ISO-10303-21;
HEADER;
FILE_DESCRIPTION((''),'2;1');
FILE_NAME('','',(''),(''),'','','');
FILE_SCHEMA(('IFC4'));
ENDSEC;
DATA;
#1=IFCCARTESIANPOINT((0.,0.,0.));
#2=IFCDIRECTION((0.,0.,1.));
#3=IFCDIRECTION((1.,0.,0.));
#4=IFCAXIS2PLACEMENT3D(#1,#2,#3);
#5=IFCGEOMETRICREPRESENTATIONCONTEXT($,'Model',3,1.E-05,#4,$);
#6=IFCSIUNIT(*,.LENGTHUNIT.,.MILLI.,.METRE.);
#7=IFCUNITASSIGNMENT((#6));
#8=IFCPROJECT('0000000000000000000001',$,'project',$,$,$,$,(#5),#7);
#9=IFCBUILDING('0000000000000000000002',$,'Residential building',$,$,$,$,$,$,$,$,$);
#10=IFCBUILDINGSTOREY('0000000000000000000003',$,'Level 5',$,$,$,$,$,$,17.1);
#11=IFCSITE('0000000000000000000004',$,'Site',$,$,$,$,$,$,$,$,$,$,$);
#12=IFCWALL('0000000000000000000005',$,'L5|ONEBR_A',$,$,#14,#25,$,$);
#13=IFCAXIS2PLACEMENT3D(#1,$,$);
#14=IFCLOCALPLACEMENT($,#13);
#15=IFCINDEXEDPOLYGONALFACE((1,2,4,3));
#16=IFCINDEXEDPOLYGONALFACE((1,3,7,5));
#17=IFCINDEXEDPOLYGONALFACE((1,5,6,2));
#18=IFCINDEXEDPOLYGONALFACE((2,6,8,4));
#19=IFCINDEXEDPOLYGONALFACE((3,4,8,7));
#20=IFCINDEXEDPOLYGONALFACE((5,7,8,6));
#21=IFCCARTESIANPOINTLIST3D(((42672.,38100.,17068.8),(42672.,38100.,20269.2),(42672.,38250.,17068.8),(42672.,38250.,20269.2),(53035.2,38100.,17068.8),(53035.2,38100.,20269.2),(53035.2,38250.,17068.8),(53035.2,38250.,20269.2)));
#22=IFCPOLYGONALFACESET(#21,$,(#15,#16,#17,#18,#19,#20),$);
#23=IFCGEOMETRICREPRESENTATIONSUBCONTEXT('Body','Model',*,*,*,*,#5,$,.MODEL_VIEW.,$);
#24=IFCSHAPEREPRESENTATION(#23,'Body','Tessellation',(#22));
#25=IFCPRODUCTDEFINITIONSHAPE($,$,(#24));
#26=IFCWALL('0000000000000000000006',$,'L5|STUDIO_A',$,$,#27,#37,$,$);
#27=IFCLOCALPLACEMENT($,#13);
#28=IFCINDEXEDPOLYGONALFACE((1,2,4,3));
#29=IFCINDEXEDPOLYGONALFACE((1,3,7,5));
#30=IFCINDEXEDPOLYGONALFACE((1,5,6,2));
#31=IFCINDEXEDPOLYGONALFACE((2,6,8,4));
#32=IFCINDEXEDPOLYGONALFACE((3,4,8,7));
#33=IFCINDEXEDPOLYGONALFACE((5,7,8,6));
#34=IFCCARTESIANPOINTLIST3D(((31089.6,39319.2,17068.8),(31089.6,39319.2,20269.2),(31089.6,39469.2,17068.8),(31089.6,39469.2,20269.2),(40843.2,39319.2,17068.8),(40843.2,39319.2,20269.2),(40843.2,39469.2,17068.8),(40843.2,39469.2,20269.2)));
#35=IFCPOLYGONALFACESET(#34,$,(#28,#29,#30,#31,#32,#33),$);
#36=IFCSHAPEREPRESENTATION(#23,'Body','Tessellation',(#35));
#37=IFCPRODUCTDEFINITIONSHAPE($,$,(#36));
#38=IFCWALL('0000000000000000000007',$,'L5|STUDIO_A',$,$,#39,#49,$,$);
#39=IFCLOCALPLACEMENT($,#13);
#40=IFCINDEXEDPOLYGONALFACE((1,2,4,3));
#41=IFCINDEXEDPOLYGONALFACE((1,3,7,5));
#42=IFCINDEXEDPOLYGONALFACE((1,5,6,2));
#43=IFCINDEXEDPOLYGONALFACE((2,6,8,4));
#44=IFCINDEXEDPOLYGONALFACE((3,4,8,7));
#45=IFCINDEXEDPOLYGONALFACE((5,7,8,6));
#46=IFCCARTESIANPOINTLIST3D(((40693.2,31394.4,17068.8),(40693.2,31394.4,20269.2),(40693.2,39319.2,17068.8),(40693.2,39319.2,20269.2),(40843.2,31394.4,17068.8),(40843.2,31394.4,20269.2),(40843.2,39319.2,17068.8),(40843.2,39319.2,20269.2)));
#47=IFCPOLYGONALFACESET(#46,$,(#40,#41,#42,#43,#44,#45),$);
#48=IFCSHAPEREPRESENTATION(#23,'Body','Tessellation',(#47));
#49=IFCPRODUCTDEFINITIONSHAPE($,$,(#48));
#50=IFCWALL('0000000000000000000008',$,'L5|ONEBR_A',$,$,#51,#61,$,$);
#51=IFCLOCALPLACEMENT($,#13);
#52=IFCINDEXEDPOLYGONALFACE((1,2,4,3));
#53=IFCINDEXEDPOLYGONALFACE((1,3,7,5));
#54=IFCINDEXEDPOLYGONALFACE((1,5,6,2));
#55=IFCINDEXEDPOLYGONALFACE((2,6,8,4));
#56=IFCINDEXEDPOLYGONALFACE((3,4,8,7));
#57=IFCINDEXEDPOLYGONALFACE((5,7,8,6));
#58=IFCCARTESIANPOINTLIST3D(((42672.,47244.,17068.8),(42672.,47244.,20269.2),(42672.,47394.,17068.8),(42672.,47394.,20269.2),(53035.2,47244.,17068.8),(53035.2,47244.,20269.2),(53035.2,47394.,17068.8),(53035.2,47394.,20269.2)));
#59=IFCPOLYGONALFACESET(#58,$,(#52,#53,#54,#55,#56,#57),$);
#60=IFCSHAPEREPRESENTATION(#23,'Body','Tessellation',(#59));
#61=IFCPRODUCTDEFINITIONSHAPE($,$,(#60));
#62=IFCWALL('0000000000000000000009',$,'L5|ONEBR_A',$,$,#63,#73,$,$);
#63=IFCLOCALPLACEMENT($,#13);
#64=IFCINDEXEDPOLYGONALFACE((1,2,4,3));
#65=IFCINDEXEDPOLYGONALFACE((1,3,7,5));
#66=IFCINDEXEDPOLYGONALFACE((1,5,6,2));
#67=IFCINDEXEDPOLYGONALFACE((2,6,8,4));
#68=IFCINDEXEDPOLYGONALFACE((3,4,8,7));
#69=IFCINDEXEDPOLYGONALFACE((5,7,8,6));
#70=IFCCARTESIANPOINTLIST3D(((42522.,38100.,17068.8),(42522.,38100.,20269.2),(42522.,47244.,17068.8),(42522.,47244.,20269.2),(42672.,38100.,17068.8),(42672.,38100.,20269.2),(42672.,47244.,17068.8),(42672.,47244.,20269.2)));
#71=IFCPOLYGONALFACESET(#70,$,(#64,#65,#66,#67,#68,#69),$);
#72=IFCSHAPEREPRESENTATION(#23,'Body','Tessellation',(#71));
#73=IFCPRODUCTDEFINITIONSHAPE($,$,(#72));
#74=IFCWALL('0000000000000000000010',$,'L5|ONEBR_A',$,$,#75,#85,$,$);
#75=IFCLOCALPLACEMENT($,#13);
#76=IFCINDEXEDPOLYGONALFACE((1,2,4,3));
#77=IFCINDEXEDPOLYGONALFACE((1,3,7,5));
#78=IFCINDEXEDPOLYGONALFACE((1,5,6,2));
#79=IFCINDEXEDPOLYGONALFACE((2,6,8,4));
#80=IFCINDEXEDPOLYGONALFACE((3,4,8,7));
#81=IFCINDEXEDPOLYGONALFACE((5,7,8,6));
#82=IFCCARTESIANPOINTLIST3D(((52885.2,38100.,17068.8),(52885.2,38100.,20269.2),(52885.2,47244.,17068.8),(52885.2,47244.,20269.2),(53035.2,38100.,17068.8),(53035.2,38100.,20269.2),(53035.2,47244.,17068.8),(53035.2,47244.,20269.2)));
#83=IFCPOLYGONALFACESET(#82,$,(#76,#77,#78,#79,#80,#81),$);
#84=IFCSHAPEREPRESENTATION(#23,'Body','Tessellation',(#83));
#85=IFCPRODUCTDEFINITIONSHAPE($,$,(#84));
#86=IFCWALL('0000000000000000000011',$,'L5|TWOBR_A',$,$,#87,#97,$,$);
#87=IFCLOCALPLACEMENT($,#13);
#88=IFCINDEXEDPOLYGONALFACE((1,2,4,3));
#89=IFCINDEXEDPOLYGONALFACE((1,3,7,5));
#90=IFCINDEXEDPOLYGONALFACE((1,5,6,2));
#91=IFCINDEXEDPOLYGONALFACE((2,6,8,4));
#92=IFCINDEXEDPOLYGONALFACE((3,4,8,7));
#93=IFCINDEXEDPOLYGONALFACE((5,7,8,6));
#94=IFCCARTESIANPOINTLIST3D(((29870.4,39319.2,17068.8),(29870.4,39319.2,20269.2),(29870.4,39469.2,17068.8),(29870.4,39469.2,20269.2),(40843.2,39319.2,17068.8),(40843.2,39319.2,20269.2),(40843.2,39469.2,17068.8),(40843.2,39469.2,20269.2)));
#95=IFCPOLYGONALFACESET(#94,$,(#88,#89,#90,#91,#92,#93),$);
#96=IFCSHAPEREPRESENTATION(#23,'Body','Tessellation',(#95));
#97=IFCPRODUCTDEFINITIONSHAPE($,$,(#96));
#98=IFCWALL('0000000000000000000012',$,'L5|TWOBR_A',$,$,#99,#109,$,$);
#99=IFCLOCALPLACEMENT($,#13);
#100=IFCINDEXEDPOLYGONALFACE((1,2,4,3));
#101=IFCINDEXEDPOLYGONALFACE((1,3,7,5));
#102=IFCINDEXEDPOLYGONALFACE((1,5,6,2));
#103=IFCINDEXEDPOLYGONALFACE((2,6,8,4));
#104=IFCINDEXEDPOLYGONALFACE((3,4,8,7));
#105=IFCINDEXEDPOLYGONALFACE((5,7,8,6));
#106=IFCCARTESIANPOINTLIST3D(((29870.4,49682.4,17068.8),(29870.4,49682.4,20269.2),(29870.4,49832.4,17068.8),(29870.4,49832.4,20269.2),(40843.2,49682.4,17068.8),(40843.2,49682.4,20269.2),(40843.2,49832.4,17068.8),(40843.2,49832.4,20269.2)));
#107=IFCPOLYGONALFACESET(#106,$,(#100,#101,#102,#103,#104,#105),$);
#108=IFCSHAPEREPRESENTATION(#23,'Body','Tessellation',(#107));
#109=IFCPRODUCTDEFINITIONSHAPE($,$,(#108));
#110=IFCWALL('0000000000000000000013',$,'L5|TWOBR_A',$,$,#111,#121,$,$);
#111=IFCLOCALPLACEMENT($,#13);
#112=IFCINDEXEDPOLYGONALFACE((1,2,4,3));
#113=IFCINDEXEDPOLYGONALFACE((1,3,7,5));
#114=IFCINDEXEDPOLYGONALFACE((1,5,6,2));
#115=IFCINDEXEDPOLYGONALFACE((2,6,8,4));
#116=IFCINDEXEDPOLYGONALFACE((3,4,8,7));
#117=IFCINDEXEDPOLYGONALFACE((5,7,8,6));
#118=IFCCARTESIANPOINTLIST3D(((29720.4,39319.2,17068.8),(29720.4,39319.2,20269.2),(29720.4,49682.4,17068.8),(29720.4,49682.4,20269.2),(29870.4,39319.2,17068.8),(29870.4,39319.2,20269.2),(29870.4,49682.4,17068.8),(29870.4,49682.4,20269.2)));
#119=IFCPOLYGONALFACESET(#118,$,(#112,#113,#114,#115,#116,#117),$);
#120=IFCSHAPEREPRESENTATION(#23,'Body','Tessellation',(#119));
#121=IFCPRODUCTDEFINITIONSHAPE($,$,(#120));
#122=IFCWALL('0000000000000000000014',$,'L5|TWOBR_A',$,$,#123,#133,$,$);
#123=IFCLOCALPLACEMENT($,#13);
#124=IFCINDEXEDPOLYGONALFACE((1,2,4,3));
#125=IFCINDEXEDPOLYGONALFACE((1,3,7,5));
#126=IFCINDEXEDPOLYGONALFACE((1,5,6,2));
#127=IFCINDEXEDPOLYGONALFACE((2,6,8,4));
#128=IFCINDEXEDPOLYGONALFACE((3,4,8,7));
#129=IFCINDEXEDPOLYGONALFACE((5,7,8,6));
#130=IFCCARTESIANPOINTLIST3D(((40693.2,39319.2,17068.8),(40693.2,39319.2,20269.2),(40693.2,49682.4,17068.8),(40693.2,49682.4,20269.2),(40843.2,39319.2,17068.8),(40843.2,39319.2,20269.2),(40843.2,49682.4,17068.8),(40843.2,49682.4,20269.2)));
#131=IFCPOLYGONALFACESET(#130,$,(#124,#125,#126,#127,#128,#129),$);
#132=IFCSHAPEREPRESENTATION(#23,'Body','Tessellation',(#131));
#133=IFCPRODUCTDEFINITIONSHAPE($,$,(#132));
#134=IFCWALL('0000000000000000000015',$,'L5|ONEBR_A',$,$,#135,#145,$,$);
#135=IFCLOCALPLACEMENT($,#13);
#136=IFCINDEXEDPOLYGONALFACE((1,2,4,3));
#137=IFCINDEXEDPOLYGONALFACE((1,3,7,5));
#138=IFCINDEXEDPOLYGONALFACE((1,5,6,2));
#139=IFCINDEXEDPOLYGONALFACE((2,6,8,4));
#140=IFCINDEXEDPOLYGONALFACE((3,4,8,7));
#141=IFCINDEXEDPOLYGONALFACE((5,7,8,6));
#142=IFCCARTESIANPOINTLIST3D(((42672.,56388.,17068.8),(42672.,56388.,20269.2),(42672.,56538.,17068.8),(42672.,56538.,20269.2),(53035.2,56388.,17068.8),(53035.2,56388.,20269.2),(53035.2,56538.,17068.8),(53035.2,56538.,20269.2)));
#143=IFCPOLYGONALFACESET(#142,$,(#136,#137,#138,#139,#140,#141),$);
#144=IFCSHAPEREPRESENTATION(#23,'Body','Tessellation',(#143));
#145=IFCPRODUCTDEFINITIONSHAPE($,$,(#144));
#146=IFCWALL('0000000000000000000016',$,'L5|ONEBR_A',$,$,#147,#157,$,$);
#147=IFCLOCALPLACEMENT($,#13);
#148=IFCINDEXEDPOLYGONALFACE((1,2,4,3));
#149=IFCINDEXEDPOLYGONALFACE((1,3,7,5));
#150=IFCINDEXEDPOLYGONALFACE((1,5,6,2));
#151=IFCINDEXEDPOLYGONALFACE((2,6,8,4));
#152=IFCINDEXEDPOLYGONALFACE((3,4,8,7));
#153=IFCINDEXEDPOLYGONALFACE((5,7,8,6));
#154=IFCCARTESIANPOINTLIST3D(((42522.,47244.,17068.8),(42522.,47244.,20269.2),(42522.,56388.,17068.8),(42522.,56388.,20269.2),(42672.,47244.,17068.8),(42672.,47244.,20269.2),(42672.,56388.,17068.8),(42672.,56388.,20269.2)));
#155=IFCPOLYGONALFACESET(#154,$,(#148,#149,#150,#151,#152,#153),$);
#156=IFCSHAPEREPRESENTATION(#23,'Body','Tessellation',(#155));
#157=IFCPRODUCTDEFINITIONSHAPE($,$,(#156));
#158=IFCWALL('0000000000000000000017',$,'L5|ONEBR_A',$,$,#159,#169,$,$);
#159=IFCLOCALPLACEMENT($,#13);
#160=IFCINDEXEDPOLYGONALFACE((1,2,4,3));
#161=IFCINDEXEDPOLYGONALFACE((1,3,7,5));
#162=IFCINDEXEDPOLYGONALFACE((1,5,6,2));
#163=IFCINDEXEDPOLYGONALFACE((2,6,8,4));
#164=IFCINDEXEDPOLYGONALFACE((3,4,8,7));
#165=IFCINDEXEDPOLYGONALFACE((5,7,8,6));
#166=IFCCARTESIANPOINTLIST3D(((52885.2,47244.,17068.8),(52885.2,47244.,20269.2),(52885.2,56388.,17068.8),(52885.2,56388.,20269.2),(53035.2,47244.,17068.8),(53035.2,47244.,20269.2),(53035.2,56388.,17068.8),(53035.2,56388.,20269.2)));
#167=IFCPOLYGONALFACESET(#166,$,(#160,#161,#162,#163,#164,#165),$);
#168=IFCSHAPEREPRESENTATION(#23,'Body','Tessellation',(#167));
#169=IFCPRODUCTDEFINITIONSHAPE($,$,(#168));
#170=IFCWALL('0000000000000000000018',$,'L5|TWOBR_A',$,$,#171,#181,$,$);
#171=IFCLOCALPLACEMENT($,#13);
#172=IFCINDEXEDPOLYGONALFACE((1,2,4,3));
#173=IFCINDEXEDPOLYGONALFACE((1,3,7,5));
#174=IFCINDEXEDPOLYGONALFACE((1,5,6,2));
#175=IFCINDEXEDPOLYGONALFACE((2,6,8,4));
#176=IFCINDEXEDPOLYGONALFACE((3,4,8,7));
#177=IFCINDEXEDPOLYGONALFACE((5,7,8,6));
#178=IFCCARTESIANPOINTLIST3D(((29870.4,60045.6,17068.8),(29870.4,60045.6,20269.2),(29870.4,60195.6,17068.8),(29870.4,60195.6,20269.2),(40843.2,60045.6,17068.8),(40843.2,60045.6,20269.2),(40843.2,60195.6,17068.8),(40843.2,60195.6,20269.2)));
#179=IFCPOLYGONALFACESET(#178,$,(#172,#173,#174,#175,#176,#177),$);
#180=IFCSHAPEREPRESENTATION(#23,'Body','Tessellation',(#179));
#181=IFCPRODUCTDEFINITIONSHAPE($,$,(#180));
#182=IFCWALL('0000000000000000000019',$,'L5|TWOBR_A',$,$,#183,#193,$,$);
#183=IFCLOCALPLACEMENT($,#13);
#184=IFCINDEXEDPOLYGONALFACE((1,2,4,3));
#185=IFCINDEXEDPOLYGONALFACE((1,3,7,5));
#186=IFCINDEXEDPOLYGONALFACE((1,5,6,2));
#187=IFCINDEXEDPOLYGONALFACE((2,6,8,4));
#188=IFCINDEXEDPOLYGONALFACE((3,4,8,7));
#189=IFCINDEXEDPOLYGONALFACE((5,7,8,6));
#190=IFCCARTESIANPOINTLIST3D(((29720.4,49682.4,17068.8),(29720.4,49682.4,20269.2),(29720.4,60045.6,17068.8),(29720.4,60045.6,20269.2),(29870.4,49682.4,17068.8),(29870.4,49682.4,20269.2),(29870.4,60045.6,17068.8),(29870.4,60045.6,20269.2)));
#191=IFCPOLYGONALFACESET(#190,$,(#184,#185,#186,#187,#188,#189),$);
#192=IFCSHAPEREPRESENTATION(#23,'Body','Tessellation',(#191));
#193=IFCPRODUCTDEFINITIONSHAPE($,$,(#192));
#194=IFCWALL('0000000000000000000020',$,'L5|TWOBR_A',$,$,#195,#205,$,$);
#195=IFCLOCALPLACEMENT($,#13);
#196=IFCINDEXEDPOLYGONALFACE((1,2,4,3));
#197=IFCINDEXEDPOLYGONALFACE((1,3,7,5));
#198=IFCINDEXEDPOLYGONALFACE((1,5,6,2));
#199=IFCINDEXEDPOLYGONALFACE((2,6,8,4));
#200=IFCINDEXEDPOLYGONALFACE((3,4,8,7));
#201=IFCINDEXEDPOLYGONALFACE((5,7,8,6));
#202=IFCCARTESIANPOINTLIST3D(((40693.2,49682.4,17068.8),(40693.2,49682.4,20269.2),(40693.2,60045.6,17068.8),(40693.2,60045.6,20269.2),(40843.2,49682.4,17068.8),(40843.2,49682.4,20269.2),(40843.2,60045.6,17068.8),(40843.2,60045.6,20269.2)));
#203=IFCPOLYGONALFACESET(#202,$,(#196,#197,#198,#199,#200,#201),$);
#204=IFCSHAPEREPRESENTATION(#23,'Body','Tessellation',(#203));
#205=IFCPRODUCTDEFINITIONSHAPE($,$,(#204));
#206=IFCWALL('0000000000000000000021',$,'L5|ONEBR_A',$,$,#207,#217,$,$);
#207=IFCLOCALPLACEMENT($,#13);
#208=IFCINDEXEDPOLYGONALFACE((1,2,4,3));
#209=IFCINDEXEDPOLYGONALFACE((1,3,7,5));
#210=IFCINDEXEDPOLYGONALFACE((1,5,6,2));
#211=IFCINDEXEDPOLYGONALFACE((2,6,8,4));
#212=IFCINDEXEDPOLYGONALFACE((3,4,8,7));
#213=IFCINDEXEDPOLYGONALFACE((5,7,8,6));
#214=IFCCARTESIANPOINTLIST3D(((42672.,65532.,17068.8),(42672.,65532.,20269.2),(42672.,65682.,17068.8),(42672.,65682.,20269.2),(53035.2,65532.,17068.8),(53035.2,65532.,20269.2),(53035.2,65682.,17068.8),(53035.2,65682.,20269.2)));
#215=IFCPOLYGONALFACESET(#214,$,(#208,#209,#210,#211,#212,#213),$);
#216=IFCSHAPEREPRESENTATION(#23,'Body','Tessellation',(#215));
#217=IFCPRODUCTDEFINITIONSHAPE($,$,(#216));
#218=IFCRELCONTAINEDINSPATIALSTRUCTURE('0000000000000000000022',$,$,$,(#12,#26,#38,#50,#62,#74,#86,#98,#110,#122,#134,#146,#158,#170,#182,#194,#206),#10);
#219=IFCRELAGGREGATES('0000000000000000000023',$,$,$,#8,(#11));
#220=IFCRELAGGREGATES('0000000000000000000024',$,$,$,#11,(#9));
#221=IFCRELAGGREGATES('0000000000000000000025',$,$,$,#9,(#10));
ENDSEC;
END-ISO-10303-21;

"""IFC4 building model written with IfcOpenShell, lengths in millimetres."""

from ifc_helpers import new_model, si_unit, frame, origin_with_axes, place, context, subcontext, project, spatial, indexed_curve, outline, extrude, element, save


model = new_model("IFC4")

# Units and contexts
model_context = context("Model", 3, precision=1e-05, world=origin_with_axes())
body_context = subcontext(model_context, "Body", "Model", "MODEL_VIEW")
ifc_project = project(units=[si_unit("LENGTHUNIT", "METRE", prefix="MILLI")], contexts=[model_context])

# Site, building, storey
site = spatial("IfcSite", under=ifc_project, Name="Site")
building = spatial("IfcBuilding", under=site, Name="Residential building")
storey = spatial("IfcBuildingStorey", under=building, Name="Level 5", Elevation=17.1)

# Walls
wall_1_placement = place(None, frame((42672.0, 38100.0, 17068.8), z_axis=(0.0, 0.0, 1.0), x_axis=(1.0, 0.0, 0.0)))
element("IfcWall", 1, at=wall_1_placement, inside=storey, Name="L5|ONEBR_A", context=body_context, shape_type="SweptSolid", body=[
    extrude(outline(indexed_curve([(0.0, 0.0), (0.0, 150.0), (10363.2, 150.0), (10363.2, 0.0), (0.0, 0.0)], self_intersect=False)), origin_with_axes(), (0.0, 0.0, 1.0), 3200.4),
])
wall_2_placement = place(None, frame((31089.6, 39319.2, 17068.8), z_axis=(0.0, 0.0, 1.0), x_axis=(1.0, 0.0, 0.0)))
element("IfcWall", 2, at=wall_2_placement, inside=storey, Name="L5|STUDIO_A", context=body_context, shape_type="SweptSolid", body=[
    extrude(outline(indexed_curve([(0.0, 0.0), (0.0, 150.0), (9753.6, 150.0), (9753.6, 0.0), (0.0, 0.0)], self_intersect=False)), origin_with_axes(), (0.0, 0.0, 1.0), 3200.4),
])
wall_3_placement = place(None, frame((40843.2, 31394.4, 17068.8), z_axis=(0.0, 0.0, 1.0), x_axis=(0.0, 1.0, 0.0)))
element("IfcWall", 3, at=wall_3_placement, inside=storey, Name="L5|STUDIO_A", context=body_context, shape_type="SweptSolid", body=[
    extrude(outline(indexed_curve([(0.0, 0.0), (0.0, 150.0), (7924.8, 150.0), (7924.8, 0.0), (0.0, 0.0)], self_intersect=False)), origin_with_axes(), (0.0, 0.0, 1.0), 3200.4),
])
for number, where, z_axis, x_axis, name in (
    (4, (42672.0, 47244.0, 17068.8), (0.0, 0.0, 1.0), (1.0, 0.0, 0.0), "L5|ONEBR_A"),
):
    element("IfcWall", number, at=place(None, frame(where, z_axis=z_axis, x_axis=x_axis)), inside=storey, Name=name, context=body_context, shape_type="SweptSolid", body=[
        extrude(outline(indexed_curve([(0.0, 0.0), (0.0, 150.0), (10363.2, 150.0), (10363.2, 0.0), (0.0, 0.0)], self_intersect=False)), origin_with_axes(), (0.0, 0.0, 1.0), 3200.4),
    ])
for number, where, z_axis, x_axis, name in (
    (5, (42672.0, 38100.0, 17068.8), (0.0, 0.0, 1.0), (0.0, 1.0, 0.0), "L5|ONEBR_A"),
    (6, (53035.2, 38100.0, 17068.8), (0.0, 0.0, 1.0), (0.0, 1.0, 0.0), "L5|ONEBR_A"),
):
    element("IfcWall", number, at=place(None, frame(where, z_axis=z_axis, x_axis=x_axis)), inside=storey, Name=name, context=body_context, shape_type="SweptSolid", body=[
        extrude(outline(indexed_curve([(0.0, 0.0), (0.0, 150.0), (9144.0, 150.0), (9144.0, 0.0), (0.0, 0.0)], self_intersect=False)), origin_with_axes(), (0.0, 0.0, 1.0), 3200.4),
    ])
for number, where, z_axis, x_axis, name in (
    (7, (29870.4, 39319.2, 17068.8), (0.0, 0.0, 1.0), (1.0, 0.0, 0.0), "L5|TWOBR_A"),
    (8, (29870.4, 49682.4, 17068.8), (0.0, 0.0, 1.0), (1.0, 0.0, 0.0), "L5|TWOBR_A"),
):
    element("IfcWall", number, at=place(None, frame(where, z_axis=z_axis, x_axis=x_axis)), inside=storey, Name=name, context=body_context, shape_type="SweptSolid", body=[
        extrude(outline(indexed_curve([(0.0, 0.0), (0.0, 150.0), (10972.8, 150.0), (10972.8, 0.0), (0.0, 0.0)], self_intersect=False)), origin_with_axes(), (0.0, 0.0, 1.0), 3200.4),
    ])
for number, where, z_axis, x_axis, name in (
    (9, (29870.4, 39319.2, 17068.8), (0.0, 0.0, 1.0), (0.0, 1.0, 0.0), "L5|TWOBR_A"),
    (10, (40843.2, 39319.2, 17068.8), (0.0, 0.0, 1.0), (0.0, 1.0, 0.0), "L5|TWOBR_A"),
    (11, (42672.0, 56388.0, 17068.8), (0.0, 0.0, 1.0), (1.0, 0.0, 0.0), "L5|ONEBR_A"),
):
    element("IfcWall", number, at=place(None, frame(where, z_axis=z_axis, x_axis=x_axis)), inside=storey, Name=name, context=body_context, shape_type="SweptSolid", body=[
        extrude(outline(indexed_curve([(0.0, 0.0), (0.0, 150.0), (10363.2, 150.0), (10363.2, 0.0), (0.0, 0.0)], self_intersect=False)), origin_with_axes(), (0.0, 0.0, 1.0), 3200.4),
    ])
for number, where, z_axis, x_axis, name in (
    (12, (42672.0, 47244.0, 17068.8), (0.0, 0.0, 1.0), (0.0, 1.0, 0.0), "L5|ONEBR_A"),
    (13, (53035.2, 47244.0, 17068.8), (0.0, 0.0, 1.0), (0.0, 1.0, 0.0), "L5|ONEBR_A"),
):
    element("IfcWall", number, at=place(None, frame(where, z_axis=z_axis, x_axis=x_axis)), inside=storey, Name=name, context=body_context, shape_type="SweptSolid", body=[
        extrude(outline(indexed_curve([(0.0, 0.0), (0.0, 150.0), (9144.0, 150.0), (9144.0, 0.0), (0.0, 0.0)], self_intersect=False)), origin_with_axes(), (0.0, 0.0, 1.0), 3200.4),
    ])
for number, where, z_axis, x_axis, name in (
    (14, (29870.4, 60045.6, 17068.8), (0.0, 0.0, 1.0), (1.0, 0.0, 0.0), "L5|TWOBR_A"),
):
    element("IfcWall", number, at=place(None, frame(where, z_axis=z_axis, x_axis=x_axis)), inside=storey, Name=name, context=body_context, shape_type="SweptSolid", body=[
        extrude(outline(indexed_curve([(0.0, 0.0), (0.0, 150.0), (10972.8, 150.0), (10972.8, 0.0), (0.0, 0.0)], self_intersect=False)), origin_with_axes(), (0.0, 0.0, 1.0), 3200.4),
    ])
for number, where, z_axis, x_axis, name in (
    (15, (29870.4, 49682.4, 17068.8), (0.0, 0.0, 1.0), (0.0, 1.0, 0.0), "L5|TWOBR_A"),
    (16, (40843.2, 49682.4, 17068.8), (0.0, 0.0, 1.0), (0.0, 1.0, 0.0), "L5|TWOBR_A"),
    (17, (42672.0, 65532.0, 17068.8), (0.0, 0.0, 1.0), (1.0, 0.0, 0.0), "L5|ONEBR_A"),
):
    element("IfcWall", number, at=place(None, frame(where, z_axis=z_axis, x_axis=x_axis)), inside=storey, Name=name, context=body_context, shape_type="SweptSolid", body=[
        extrude(outline(indexed_curve([(0.0, 0.0), (0.0, 150.0), (10363.2, 150.0), (10363.2, 0.0), (0.0, 0.0)], self_intersect=False)), origin_with_axes(), (0.0, 0.0, 1.0), 3200.4),
    ])

save(model, "model.ifc")
